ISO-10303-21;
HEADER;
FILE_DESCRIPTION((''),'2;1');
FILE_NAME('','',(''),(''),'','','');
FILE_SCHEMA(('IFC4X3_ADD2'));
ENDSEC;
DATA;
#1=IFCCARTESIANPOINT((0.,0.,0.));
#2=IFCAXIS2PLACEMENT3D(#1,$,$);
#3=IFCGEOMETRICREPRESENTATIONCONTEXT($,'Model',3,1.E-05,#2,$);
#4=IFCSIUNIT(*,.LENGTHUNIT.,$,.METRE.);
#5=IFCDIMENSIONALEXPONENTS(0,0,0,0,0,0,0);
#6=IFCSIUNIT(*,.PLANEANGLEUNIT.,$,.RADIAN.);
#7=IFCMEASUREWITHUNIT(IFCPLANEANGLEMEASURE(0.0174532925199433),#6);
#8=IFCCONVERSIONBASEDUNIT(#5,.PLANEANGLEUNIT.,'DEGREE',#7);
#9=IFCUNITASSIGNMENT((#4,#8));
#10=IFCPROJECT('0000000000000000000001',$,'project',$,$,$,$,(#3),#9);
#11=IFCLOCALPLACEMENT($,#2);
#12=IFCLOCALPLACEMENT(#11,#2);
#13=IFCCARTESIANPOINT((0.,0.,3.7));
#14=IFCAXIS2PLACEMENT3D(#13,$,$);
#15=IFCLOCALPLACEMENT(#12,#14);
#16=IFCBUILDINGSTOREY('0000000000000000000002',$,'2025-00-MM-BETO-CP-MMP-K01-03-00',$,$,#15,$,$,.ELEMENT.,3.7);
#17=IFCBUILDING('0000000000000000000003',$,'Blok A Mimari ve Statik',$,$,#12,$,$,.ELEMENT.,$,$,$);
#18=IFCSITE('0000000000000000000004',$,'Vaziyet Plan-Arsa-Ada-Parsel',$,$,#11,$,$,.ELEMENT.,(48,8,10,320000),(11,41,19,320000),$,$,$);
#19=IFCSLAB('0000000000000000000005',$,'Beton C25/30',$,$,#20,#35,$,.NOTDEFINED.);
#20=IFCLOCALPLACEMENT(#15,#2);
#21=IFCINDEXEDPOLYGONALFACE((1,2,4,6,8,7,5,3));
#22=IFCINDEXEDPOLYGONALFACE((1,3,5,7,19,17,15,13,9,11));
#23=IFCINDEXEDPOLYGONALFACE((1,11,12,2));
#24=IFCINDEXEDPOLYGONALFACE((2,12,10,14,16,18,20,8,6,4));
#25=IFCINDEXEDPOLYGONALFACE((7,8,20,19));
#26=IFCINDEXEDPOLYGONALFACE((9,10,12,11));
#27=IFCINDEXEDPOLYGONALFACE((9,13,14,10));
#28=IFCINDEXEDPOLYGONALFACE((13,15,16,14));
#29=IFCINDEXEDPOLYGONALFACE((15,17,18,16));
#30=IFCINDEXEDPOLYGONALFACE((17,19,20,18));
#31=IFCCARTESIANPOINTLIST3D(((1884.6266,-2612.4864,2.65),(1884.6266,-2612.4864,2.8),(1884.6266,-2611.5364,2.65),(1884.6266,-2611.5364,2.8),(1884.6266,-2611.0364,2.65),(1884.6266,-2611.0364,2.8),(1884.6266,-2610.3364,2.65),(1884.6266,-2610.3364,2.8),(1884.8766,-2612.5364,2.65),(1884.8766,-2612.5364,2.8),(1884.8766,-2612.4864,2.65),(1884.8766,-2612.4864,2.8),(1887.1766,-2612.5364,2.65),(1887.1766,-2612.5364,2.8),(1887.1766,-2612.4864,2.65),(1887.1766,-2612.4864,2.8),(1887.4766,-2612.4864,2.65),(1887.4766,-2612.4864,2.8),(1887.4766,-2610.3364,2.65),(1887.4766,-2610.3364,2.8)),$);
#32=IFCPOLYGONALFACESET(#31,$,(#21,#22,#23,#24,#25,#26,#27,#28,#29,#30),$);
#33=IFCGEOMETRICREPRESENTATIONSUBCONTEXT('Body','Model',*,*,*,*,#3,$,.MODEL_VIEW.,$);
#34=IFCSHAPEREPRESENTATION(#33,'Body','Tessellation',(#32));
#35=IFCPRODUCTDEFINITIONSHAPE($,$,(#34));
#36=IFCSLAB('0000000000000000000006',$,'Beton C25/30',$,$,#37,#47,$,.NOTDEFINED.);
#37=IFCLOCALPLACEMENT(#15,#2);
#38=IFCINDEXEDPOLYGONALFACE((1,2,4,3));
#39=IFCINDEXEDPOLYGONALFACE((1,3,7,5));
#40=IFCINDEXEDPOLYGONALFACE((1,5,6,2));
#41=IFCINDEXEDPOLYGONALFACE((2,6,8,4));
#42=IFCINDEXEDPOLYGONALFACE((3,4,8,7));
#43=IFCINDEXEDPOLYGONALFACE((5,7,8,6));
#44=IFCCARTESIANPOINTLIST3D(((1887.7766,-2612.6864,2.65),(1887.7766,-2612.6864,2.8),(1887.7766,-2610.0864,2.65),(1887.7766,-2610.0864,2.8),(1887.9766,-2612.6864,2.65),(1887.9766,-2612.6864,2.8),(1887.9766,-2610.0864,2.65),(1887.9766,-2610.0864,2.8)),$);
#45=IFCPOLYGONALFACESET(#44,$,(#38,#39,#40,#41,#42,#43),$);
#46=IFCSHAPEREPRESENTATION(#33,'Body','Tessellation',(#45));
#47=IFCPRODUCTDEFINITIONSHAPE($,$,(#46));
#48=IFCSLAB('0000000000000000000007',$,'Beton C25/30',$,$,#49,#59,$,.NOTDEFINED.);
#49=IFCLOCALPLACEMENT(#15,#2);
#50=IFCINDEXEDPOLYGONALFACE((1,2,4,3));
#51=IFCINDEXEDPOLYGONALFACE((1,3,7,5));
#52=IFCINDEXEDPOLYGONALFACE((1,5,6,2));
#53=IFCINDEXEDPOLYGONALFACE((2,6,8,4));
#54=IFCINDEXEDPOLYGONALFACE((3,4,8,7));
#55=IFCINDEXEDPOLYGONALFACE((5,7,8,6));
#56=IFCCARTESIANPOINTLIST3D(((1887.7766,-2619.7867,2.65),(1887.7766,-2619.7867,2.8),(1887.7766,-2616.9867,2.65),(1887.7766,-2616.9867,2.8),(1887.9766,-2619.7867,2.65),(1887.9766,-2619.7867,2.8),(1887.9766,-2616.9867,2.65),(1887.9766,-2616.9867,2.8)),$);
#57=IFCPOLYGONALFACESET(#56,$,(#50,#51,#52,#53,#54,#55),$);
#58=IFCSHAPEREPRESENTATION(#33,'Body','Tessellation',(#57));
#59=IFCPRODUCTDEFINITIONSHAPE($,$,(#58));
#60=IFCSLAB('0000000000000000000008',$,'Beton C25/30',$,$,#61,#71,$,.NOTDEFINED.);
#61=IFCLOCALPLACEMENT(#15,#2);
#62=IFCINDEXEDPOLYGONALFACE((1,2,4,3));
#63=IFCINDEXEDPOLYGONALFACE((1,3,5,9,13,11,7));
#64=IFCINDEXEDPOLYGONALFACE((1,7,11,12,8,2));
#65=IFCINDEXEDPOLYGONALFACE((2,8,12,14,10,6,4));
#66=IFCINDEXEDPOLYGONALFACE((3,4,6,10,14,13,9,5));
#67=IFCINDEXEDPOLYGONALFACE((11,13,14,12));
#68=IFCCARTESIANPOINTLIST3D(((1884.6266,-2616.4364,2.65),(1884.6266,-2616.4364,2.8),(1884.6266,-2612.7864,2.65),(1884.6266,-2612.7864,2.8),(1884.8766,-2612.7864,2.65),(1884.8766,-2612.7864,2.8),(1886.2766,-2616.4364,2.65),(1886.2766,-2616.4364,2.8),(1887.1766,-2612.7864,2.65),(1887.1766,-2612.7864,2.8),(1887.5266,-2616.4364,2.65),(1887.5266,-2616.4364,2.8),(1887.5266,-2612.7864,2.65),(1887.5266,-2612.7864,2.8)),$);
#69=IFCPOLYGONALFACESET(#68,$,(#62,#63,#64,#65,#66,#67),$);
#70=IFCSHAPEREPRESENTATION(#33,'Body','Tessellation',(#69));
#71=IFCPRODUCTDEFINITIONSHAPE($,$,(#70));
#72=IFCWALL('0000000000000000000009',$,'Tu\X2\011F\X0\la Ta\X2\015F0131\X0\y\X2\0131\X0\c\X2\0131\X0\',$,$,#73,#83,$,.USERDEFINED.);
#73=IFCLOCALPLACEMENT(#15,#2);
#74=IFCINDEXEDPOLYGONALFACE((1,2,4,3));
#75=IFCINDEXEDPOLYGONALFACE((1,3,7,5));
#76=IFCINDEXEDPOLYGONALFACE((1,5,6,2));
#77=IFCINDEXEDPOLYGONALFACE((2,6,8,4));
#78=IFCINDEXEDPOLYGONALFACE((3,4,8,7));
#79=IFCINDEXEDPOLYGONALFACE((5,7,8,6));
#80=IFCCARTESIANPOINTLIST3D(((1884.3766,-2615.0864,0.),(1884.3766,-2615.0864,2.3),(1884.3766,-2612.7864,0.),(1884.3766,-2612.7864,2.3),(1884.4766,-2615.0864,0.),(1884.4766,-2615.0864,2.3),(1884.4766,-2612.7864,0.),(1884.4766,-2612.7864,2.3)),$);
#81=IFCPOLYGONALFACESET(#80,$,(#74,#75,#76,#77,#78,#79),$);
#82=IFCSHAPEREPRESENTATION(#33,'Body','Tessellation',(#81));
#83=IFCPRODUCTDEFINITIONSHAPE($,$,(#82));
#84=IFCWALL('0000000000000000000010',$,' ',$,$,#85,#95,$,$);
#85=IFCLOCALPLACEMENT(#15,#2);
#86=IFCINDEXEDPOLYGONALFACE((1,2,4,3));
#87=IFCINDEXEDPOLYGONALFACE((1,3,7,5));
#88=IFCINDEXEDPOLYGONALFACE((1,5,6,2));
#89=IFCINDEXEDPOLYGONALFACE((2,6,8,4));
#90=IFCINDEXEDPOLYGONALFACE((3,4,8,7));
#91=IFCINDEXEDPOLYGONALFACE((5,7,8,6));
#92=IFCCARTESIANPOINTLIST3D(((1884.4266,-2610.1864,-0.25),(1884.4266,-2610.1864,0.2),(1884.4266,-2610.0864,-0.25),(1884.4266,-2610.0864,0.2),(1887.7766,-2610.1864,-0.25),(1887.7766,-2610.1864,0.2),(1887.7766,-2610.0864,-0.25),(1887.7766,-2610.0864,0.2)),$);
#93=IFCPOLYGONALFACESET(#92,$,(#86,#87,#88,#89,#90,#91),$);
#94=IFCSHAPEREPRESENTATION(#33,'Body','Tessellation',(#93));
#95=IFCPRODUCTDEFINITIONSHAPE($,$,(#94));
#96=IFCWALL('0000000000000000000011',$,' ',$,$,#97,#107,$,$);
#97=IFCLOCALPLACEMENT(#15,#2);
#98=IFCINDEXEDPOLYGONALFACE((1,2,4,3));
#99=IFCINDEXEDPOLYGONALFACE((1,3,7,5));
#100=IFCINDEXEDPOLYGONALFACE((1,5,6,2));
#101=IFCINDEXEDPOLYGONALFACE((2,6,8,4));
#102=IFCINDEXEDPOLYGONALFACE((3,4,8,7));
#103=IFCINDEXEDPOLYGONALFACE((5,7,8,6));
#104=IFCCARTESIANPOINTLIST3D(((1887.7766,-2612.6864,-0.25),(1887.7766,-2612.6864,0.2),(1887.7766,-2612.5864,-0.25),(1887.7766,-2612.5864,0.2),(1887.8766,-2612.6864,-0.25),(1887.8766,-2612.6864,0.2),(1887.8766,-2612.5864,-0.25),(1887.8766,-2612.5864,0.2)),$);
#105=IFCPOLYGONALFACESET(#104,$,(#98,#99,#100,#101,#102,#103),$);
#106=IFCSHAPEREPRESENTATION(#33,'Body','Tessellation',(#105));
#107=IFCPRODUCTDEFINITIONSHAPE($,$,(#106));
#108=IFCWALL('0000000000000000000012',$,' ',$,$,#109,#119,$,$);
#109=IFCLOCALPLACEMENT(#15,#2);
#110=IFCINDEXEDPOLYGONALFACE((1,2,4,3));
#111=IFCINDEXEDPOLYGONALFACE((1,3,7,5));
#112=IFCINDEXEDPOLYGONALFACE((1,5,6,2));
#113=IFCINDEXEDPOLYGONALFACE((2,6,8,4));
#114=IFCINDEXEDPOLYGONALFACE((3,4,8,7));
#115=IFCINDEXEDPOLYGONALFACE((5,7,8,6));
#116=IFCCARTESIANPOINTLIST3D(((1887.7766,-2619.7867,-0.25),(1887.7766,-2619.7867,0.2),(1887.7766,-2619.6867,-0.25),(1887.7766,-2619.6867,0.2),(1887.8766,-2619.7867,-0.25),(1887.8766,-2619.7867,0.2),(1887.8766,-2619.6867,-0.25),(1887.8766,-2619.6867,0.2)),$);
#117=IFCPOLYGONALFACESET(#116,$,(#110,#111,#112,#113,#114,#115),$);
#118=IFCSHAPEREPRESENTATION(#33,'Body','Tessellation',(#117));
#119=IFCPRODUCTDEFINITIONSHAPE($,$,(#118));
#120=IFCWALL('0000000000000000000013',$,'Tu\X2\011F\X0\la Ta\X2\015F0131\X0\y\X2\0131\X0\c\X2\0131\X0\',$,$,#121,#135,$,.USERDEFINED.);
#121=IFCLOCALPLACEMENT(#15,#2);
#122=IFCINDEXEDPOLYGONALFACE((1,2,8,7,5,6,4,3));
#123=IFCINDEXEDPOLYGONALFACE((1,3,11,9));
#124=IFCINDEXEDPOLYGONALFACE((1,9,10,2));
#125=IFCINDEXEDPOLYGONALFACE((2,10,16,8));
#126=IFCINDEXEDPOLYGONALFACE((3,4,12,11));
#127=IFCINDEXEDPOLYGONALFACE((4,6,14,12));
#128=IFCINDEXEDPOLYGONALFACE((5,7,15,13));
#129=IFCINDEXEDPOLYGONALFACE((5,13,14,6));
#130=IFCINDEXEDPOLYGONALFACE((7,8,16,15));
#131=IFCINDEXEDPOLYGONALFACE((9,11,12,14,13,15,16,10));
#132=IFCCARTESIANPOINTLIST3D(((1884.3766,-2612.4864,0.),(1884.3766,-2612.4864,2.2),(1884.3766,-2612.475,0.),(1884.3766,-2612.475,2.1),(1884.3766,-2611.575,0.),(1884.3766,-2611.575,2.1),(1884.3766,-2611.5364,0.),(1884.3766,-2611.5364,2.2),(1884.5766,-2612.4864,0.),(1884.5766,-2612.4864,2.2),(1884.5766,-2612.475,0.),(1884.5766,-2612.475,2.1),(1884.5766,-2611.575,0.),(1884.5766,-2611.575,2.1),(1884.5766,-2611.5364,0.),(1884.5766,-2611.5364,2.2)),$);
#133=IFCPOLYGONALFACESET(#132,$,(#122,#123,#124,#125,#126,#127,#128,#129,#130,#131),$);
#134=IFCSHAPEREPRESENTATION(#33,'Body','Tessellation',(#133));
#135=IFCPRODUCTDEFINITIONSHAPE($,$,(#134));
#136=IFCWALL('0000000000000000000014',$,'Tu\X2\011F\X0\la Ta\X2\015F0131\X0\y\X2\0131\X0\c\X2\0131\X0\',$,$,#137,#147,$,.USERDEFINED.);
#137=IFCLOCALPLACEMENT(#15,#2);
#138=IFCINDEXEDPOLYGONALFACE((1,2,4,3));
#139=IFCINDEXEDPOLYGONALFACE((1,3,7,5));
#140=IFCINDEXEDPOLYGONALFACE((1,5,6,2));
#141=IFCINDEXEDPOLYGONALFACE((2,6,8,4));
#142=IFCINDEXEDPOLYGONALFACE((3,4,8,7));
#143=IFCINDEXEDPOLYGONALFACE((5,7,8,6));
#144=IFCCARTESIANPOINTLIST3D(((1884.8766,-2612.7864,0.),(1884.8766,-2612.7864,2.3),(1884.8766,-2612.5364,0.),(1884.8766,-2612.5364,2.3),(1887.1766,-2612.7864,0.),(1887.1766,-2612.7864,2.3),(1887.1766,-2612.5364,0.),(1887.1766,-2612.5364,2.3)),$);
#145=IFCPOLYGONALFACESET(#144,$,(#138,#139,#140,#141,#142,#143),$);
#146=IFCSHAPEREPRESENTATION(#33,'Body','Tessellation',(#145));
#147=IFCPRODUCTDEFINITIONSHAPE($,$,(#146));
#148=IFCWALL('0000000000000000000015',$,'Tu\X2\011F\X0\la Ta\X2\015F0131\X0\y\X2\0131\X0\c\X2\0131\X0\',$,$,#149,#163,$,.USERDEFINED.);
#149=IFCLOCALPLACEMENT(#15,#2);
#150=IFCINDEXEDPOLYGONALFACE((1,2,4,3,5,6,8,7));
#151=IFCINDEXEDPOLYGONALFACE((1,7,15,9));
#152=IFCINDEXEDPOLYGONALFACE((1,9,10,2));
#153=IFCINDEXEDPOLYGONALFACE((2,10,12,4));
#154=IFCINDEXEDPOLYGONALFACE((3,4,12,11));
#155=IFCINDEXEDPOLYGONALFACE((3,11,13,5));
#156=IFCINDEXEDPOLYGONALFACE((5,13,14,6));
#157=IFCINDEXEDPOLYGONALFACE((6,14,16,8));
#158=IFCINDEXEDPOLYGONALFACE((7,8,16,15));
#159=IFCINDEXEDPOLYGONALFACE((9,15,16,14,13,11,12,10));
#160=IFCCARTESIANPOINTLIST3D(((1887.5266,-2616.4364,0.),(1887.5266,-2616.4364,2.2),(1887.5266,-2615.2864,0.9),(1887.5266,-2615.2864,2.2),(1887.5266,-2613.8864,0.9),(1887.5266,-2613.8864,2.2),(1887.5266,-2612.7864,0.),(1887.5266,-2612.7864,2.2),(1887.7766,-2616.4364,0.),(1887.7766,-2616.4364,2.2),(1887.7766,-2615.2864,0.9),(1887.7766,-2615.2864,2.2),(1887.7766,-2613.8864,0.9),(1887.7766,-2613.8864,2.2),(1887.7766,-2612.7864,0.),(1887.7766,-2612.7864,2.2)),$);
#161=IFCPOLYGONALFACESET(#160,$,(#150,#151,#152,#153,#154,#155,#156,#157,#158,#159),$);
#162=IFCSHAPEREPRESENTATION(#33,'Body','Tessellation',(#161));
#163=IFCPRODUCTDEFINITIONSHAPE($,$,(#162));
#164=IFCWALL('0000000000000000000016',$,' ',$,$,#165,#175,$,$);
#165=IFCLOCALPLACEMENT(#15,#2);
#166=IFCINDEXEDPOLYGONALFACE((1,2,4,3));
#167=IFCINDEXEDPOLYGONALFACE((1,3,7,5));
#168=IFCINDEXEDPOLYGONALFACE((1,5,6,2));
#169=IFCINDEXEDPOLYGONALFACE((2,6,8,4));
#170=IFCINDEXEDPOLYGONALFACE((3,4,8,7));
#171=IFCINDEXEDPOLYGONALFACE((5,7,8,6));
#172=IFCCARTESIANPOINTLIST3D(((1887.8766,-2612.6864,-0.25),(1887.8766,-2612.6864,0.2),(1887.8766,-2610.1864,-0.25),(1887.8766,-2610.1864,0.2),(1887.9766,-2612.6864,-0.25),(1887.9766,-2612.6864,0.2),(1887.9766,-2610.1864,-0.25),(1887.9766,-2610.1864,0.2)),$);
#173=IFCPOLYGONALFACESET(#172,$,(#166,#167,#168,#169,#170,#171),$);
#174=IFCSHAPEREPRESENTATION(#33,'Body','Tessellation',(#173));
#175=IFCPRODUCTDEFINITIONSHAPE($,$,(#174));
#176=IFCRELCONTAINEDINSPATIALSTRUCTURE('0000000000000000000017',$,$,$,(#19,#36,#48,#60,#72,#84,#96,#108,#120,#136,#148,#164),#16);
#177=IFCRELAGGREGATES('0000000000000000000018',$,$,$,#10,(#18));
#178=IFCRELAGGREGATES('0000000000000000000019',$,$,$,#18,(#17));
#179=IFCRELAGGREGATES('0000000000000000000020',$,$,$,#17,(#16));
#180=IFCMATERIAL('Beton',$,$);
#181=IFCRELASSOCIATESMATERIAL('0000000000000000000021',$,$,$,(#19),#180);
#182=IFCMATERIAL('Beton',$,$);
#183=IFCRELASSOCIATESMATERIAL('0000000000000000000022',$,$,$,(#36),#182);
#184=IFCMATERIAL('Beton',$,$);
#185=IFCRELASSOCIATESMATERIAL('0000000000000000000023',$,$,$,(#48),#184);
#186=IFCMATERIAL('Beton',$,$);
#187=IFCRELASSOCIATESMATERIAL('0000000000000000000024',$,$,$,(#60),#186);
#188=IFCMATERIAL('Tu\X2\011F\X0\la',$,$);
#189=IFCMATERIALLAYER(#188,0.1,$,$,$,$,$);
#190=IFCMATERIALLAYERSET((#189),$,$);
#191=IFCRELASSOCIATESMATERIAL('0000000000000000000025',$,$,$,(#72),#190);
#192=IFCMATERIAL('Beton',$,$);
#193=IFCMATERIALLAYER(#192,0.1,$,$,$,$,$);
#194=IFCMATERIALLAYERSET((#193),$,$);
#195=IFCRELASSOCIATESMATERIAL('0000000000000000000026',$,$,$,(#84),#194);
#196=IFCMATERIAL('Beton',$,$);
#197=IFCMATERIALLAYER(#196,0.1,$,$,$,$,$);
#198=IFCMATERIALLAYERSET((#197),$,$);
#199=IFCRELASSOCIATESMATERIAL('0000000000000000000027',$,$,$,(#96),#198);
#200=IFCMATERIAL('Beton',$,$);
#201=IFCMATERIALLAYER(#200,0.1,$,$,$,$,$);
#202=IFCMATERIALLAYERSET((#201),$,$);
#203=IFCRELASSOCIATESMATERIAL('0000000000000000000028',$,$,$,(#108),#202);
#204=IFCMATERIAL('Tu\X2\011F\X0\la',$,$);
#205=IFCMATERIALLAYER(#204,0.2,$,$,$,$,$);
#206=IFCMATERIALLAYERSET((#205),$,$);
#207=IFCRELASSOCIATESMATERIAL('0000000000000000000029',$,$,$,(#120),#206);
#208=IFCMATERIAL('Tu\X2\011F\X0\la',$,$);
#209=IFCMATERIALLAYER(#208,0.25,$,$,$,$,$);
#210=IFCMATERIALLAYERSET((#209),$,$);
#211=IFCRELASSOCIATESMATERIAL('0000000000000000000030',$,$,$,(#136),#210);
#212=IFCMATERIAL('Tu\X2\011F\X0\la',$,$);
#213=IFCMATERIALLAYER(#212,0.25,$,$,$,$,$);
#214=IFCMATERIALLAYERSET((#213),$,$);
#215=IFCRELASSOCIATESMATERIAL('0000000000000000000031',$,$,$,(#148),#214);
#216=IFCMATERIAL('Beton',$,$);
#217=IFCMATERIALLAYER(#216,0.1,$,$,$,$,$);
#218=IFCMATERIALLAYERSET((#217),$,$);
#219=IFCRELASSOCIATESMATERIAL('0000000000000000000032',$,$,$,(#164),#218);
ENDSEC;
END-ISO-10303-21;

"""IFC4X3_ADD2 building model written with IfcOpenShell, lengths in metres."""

from ifc_helpers import new_model, entity, si_unit, converted_unit, frame, frame_2d, origin, origin_with_axes, place, context, subcontext, project, spatial, polyline, rectangle, outline, extrude, material, layer, layer_set, layer_usage, element, save


model = new_model("IFC4X3_ADD2")

# Units and contexts
model_context = context("Model", 3, precision=1e-05, world=origin())
body_context = subcontext(model_context, "Body", "Model", "MODEL_VIEW")
ifc_project = project(units=[si_unit("LENGTHUNIT", "METRE"), converted_unit("PLANEANGLEUNIT", "DEGREE", entity("IfcPlaneAngleMeasure", 0.0174532925199433), si_unit("PLANEANGLEUNIT", "RADIAN"), dimensions=[0, 0, 0, 0, 0, 0, 0])], contexts=[model_context])

# Site, building, storey
site_placement = place(None, origin())
site = spatial("IfcSite", under=ifc_project, at=site_placement, Name="Vaziyet Plan-Arsa-Ada-Parsel", CompositionType="ELEMENT", RefLatitude=(48, 8, 10, 320000), RefLongitude=(11, 41, 19, 320000))
building_placement = place(site_placement, origin())
building = spatial("IfcBuilding", under=site, at=building_placement, Name="Blok A Mimari ve Statik", CompositionType="ELEMENT")
storey_placement = place(building_placement, frame((0.0, 0.0, 3.7)))
storey = spatial("IfcBuildingStorey", under=building, at=storey_placement, Name="2025-00-MM-BETO-CP-MMP-K01-03-00", CompositionType="ELEMENT", Elevation=3.7)

# Slabs
ifc_material_1 = material(Name="Beton")
slab_1_placement = place(storey_placement, frame((1884.6266, -2612.5364, 2.65)))
element("IfcSlab", 1, at=slab_1_placement, inside=storey, material=ifc_material_1, Name="Beton C25/30", PredefinedType="NOTDEFINED", context=body_context, shape_type="SweptSolid", body=[
    extrude(outline(polyline([(0.0, 1.5), (0.0, 1.0), (0.0, 0.05), (0.25, 0.05), (0.25, 0.0), (2.55, 0.0), (2.55, 0.05), (2.85, 0.05), (2.85, 2.2), (0.0, 2.2), (0.0, 1.5)])), origin_with_axes(), (0.0, 0.0, 1.0), 0.15),
])
ifc_material_2 = material(Name="Beton")
slab_2_placement = place(storey_placement, frame((1887.7766, -2612.6864, 2.65)))
element("IfcSlab", 2, at=slab_2_placement, inside=storey, material=ifc_material_2, Name="Beton C25/30", PredefinedType="NOTDEFINED", context=body_context, shape_type="SweptSolid", body=[
    extrude(rectangle(XDim=2.6, YDim=0.2, at=frame_2d((-0.1, 1.3), x_axis=(0.0, 1.0))), frame((0.2, 0.0, 0.0), z_axis=(0.0, 0.0, 1.0), x_axis=(1.0, 0.0, 0.0)), (0.0, 0.0, 1.0), 0.15),
])
ifc_material_3 = material(Name="Beton")
slab_3_placement = place(storey_placement, frame((1887.7766, -2619.7867, 2.65)))
element("IfcSlab", 3, at=slab_3_placement, inside=storey, material=ifc_material_3, Name="Beton C25/30", PredefinedType="NOTDEFINED", context=body_context, shape_type="SweptSolid", body=[
    extrude(rectangle(XDim=2.8, YDim=0.2, at=frame_2d((-0.1, 1.4), x_axis=(0.0, 1.0))), frame((0.2, 0.0, 0.0), z_axis=(0.0, 0.0, 1.0), x_axis=(1.0, 0.0, 0.0)), (0.0, 0.0, 1.0), 0.15),
])
ifc_material_4 = material(Name="Beton")
slab_4_placement = place(storey_placement, frame((1884.6266, -2616.4364, 2.65)))
element("IfcSlab", 4, at=slab_4_placement, inside=storey, material=ifc_material_4, Name="Beton C25/30", PredefinedType="NOTDEFINED", context=body_context, shape_type="SweptSolid", body=[
    extrude(outline(polyline([(0.25, 3.65), (0.0, 3.65), (0.0, 0.0), (1.65, 0.0), (2.9, 0.0), (2.9, 3.65), (2.55, 3.65), (0.25, 3.65)])), origin_with_axes(), (0.0, 0.0, 1.0), 0.15),
])

# Walls
ifc_material_5 = material(Name="Tuğla")
ifc_layer_1 = layer(ifc_material_5, 0.1)
ifc_layer_set_1 = layer_set([ifc_layer_1])
ifc_layer_usage_1 = layer_usage(ifc_layer_set_1, "AXIS2", "POSITIVE", 0.0)
wall_1_placement = place(storey_placement, frame((1884.4766, -2615.0864, 0.0), z_axis=(0.0, 0.0, 1.0), x_axis=(0.0, 1.0, 0.0)))
element("IfcWall", 5, at=wall_1_placement, inside=storey, material=ifc_layer_usage_1, Name="Tuğla Taşıyıcı", PredefinedType="USERDEFINED", context=body_context, shape_type="SweptSolid", body=[
    extrude(rectangle(XDim=2.3, YDim=0.1, at=frame_2d((1.15, 0.05), x_axis=(1.0, 0.0))), origin_with_axes(), (0.0, 0.0, 1.0), 2.3),
])
ifc_material_6 = material(Name="Beton")
ifc_layer_2 = layer(ifc_material_6, 0.1)
ifc_layer_set_2 = layer_set([ifc_layer_2])
ifc_layer_usage_2 = layer_usage(ifc_layer_set_2, "AXIS2", "POSITIVE", 0.0)
wall_2_placement = place(storey_placement, frame((1887.7766, -2610.0864, -0.25), z_axis=(0.0, 0.0, 1.0), x_axis=(-1.0, 0.0, 0.0)))
element("IfcWall", 6, at=wall_2_placement, inside=storey, material=ifc_layer_usage_2, Name=" ", context=body_context, shape_type="SweptSolid", body=[
    extrude(rectangle(XDim=3.35, YDim=0.1, at=frame_2d((1.675, 0.05), x_axis=(1.0, 0.0))), origin_with_axes(), (0.0, 0.0, 1.0), 0.45),
])
ifc_material_7 = material(Name="Beton")
ifc_layer_3 = layer(ifc_material_7, 0.1)
ifc_layer_set_3 = layer_set([ifc_layer_3])
ifc_layer_usage_3 = layer_usage(ifc_layer_set_3, "AXIS2", "POSITIVE", 0.0)
wall_3_placement = place(storey_placement, frame((1887.7766, -2612.6864, -0.25)))
element("IfcWall", 7, at=wall_3_placement, inside=storey, material=ifc_layer_usage_3, Name=" ", context=body_context, shape_type="SweptSolid", body=[
    extrude(rectangle(XDim=0.1, YDim=0.1, at=frame_2d((0.05, 0.05), x_axis=(1.0, 0.0))), origin_with_axes(), (0.0, 0.0, 1.0), 0.45),
])
ifc_material_8 = material(Name="Beton")
ifc_layer_4 = layer(ifc_material_8, 0.1)
ifc_layer_set_4 = layer_set([ifc_layer_4])
ifc_layer_usage_4 = layer_usage(ifc_layer_set_4, "AXIS2", "POSITIVE", 0.0)
wall_4_placement = place(storey_placement, frame((1887.7766, -2619.7867, -0.25)))
element("IfcWall", 8, at=wall_4_placement, inside=storey, material=ifc_layer_usage_4, Name=" ", context=body_context, shape_type="SweptSolid", body=[
    extrude(rectangle(XDim=0.1, YDim=0.1, at=frame_2d((0.05, 0.05), x_axis=(1.0, 0.0))), origin_with_axes(), (0.0, 0.0, 1.0), 0.45),
])

# Wall, opening
ifc_material_9 = material(Name="Tuğla")
ifc_layer_5 = layer(ifc_material_9, 0.2)
ifc_layer_set_5 = layer_set([ifc_layer_5])
ifc_layer_usage_5 = layer_usage(ifc_layer_set_5, "AXIS2", "POSITIVE", 0.0)
wall_5_placement = place(storey_placement, frame((1884.3766, -2611.5364, 0.0), z_axis=(0.0, 0.0, 1.0), x_axis=(0.0, -1.0, 0.0)))
wall_5 = element("IfcWall", 9, at=wall_5_placement, inside=storey, material=ifc_layer_usage_5, Name="Tuğla Taşıyıcı", PredefinedType="USERDEFINED", context=body_context, shape_type="SweptSolid", body=[
    extrude(rectangle(XDim=0.95, YDim=0.2, at=frame_2d((0.475, 0.1), x_axis=(1.0, 0.0))), origin_with_axes(), (0.0, 0.0, 1.0), 2.2),
])
opening_1_placement = place(wall_5_placement, frame((0.9386, 0.2, 0.0), z_axis=(0.0, -1.0, 0.0), x_axis=(0.0, 0.0, 1.0)))
element("IfcOpeningElement", 10, at=opening_1_placement, cuts=wall_5, PredefinedType="OPENING", context=body_context, shape_type="SweptSolid", body=[
    extrude(outline(polyline([(2.1, 0.9), (2.1, 0.0), (0.0, 0.0), (0.0, 0.9), (2.1, 0.9)])), origin_with_axes(), (0.0, 0.0, 1.0), 0.2),
])

# Wall
ifc_material_10 = material(Name="Tuğla")
ifc_layer_6 = layer(ifc_material_10, 0.25)
ifc_layer_set_6 = layer_set([ifc_layer_6])
ifc_layer_usage_6 = layer_usage(ifc_layer_set_6, "AXIS2", "POSITIVE", 0.0)
wall_6_placement = place(storey_placement, frame((1887.1766, -2612.5364, 0.0), z_axis=(0.0, 0.0, 1.0), x_axis=(-1.0, 0.0, 0.0)))
element("IfcWall", 11, at=wall_6_placement, inside=storey, material=ifc_layer_usage_6, Name="Tuğla Taşıyıcı", PredefinedType="USERDEFINED", context=body_context, shape_type="SweptSolid", body=[
    extrude(rectangle(XDim=2.3, YDim=0.25, at=frame_2d((1.15, 0.125), x_axis=(1.0, 0.0))), origin_with_axes(), (0.0, 0.0, 1.0), 2.3),
])

# Wall, opening
ifc_material_11 = material(Name="Tuğla")
ifc_layer_7 = layer(ifc_material_11, 0.25)
ifc_layer_set_7 = layer_set([ifc_layer_7])
ifc_layer_usage_7 = layer_usage(ifc_layer_set_7, "AXIS2", "POSITIVE", 0.0)
wall_7_placement = place(storey_placement, frame((1887.7766, -2616.4364, 0.0), z_axis=(0.0, 0.0, 1.0), x_axis=(0.0, 1.0, 0.0)))
wall_7 = element("IfcWall", 12, at=wall_7_placement, inside=storey, material=ifc_layer_usage_7, Name="Tuğla Taşıyıcı", PredefinedType="USERDEFINED", context=body_context, shape_type="SweptSolid", body=[
    extrude(rectangle(XDim=3.65, YDim=0.25, at=frame_2d((1.825, 0.125), x_axis=(1.0, 0.0))), origin_with_axes(), (0.0, 0.0, 1.0), 2.2),
])
opening_2_placement = place(wall_7_placement, frame((1.15, 0.0, 0.9), z_axis=(0.0, 1.0, 0.0), x_axis=(0.0, 0.0, 1.0)))
element("IfcOpeningElement", 13, at=opening_2_placement, cuts=wall_7, PredefinedType="OPENING", context=body_context, shape_type="SweptSolid", body=[
    extrude(outline(polyline([(1.35, 1.4), (1.35, 0.0), (0.0, 0.0), (0.0, 1.4), (1.35, 1.4)])), origin_with_axes(), (0.0, 0.0, 1.0), 0.25),
])

# Wall
ifc_material_12 = material(Name="Beton")
ifc_layer_8 = layer(ifc_material_12, 0.1)
ifc_layer_set_8 = layer_set([ifc_layer_8])
ifc_layer_usage_8 = layer_usage(ifc_layer_set_8, "AXIS2", "POSITIVE", 0.0)
wall_8_placement = place(storey_placement, frame((1887.9766, -2612.6864, -0.25), z_axis=(0.0, 0.0, 1.0), x_axis=(0.0, 1.0, 0.0)))
element("IfcWall", 14, at=wall_8_placement, inside=storey, material=ifc_layer_usage_8, Name=" ", context=body_context, shape_type="SweptSolid", body=[
    extrude(rectangle(XDim=2.5, YDim=0.1, at=frame_2d((1.25, 0.05), x_axis=(1.0, 0.0))), origin_with_axes(), (0.0, 0.0, 1.0), 0.45),
])

save(model, "model.ifc")
